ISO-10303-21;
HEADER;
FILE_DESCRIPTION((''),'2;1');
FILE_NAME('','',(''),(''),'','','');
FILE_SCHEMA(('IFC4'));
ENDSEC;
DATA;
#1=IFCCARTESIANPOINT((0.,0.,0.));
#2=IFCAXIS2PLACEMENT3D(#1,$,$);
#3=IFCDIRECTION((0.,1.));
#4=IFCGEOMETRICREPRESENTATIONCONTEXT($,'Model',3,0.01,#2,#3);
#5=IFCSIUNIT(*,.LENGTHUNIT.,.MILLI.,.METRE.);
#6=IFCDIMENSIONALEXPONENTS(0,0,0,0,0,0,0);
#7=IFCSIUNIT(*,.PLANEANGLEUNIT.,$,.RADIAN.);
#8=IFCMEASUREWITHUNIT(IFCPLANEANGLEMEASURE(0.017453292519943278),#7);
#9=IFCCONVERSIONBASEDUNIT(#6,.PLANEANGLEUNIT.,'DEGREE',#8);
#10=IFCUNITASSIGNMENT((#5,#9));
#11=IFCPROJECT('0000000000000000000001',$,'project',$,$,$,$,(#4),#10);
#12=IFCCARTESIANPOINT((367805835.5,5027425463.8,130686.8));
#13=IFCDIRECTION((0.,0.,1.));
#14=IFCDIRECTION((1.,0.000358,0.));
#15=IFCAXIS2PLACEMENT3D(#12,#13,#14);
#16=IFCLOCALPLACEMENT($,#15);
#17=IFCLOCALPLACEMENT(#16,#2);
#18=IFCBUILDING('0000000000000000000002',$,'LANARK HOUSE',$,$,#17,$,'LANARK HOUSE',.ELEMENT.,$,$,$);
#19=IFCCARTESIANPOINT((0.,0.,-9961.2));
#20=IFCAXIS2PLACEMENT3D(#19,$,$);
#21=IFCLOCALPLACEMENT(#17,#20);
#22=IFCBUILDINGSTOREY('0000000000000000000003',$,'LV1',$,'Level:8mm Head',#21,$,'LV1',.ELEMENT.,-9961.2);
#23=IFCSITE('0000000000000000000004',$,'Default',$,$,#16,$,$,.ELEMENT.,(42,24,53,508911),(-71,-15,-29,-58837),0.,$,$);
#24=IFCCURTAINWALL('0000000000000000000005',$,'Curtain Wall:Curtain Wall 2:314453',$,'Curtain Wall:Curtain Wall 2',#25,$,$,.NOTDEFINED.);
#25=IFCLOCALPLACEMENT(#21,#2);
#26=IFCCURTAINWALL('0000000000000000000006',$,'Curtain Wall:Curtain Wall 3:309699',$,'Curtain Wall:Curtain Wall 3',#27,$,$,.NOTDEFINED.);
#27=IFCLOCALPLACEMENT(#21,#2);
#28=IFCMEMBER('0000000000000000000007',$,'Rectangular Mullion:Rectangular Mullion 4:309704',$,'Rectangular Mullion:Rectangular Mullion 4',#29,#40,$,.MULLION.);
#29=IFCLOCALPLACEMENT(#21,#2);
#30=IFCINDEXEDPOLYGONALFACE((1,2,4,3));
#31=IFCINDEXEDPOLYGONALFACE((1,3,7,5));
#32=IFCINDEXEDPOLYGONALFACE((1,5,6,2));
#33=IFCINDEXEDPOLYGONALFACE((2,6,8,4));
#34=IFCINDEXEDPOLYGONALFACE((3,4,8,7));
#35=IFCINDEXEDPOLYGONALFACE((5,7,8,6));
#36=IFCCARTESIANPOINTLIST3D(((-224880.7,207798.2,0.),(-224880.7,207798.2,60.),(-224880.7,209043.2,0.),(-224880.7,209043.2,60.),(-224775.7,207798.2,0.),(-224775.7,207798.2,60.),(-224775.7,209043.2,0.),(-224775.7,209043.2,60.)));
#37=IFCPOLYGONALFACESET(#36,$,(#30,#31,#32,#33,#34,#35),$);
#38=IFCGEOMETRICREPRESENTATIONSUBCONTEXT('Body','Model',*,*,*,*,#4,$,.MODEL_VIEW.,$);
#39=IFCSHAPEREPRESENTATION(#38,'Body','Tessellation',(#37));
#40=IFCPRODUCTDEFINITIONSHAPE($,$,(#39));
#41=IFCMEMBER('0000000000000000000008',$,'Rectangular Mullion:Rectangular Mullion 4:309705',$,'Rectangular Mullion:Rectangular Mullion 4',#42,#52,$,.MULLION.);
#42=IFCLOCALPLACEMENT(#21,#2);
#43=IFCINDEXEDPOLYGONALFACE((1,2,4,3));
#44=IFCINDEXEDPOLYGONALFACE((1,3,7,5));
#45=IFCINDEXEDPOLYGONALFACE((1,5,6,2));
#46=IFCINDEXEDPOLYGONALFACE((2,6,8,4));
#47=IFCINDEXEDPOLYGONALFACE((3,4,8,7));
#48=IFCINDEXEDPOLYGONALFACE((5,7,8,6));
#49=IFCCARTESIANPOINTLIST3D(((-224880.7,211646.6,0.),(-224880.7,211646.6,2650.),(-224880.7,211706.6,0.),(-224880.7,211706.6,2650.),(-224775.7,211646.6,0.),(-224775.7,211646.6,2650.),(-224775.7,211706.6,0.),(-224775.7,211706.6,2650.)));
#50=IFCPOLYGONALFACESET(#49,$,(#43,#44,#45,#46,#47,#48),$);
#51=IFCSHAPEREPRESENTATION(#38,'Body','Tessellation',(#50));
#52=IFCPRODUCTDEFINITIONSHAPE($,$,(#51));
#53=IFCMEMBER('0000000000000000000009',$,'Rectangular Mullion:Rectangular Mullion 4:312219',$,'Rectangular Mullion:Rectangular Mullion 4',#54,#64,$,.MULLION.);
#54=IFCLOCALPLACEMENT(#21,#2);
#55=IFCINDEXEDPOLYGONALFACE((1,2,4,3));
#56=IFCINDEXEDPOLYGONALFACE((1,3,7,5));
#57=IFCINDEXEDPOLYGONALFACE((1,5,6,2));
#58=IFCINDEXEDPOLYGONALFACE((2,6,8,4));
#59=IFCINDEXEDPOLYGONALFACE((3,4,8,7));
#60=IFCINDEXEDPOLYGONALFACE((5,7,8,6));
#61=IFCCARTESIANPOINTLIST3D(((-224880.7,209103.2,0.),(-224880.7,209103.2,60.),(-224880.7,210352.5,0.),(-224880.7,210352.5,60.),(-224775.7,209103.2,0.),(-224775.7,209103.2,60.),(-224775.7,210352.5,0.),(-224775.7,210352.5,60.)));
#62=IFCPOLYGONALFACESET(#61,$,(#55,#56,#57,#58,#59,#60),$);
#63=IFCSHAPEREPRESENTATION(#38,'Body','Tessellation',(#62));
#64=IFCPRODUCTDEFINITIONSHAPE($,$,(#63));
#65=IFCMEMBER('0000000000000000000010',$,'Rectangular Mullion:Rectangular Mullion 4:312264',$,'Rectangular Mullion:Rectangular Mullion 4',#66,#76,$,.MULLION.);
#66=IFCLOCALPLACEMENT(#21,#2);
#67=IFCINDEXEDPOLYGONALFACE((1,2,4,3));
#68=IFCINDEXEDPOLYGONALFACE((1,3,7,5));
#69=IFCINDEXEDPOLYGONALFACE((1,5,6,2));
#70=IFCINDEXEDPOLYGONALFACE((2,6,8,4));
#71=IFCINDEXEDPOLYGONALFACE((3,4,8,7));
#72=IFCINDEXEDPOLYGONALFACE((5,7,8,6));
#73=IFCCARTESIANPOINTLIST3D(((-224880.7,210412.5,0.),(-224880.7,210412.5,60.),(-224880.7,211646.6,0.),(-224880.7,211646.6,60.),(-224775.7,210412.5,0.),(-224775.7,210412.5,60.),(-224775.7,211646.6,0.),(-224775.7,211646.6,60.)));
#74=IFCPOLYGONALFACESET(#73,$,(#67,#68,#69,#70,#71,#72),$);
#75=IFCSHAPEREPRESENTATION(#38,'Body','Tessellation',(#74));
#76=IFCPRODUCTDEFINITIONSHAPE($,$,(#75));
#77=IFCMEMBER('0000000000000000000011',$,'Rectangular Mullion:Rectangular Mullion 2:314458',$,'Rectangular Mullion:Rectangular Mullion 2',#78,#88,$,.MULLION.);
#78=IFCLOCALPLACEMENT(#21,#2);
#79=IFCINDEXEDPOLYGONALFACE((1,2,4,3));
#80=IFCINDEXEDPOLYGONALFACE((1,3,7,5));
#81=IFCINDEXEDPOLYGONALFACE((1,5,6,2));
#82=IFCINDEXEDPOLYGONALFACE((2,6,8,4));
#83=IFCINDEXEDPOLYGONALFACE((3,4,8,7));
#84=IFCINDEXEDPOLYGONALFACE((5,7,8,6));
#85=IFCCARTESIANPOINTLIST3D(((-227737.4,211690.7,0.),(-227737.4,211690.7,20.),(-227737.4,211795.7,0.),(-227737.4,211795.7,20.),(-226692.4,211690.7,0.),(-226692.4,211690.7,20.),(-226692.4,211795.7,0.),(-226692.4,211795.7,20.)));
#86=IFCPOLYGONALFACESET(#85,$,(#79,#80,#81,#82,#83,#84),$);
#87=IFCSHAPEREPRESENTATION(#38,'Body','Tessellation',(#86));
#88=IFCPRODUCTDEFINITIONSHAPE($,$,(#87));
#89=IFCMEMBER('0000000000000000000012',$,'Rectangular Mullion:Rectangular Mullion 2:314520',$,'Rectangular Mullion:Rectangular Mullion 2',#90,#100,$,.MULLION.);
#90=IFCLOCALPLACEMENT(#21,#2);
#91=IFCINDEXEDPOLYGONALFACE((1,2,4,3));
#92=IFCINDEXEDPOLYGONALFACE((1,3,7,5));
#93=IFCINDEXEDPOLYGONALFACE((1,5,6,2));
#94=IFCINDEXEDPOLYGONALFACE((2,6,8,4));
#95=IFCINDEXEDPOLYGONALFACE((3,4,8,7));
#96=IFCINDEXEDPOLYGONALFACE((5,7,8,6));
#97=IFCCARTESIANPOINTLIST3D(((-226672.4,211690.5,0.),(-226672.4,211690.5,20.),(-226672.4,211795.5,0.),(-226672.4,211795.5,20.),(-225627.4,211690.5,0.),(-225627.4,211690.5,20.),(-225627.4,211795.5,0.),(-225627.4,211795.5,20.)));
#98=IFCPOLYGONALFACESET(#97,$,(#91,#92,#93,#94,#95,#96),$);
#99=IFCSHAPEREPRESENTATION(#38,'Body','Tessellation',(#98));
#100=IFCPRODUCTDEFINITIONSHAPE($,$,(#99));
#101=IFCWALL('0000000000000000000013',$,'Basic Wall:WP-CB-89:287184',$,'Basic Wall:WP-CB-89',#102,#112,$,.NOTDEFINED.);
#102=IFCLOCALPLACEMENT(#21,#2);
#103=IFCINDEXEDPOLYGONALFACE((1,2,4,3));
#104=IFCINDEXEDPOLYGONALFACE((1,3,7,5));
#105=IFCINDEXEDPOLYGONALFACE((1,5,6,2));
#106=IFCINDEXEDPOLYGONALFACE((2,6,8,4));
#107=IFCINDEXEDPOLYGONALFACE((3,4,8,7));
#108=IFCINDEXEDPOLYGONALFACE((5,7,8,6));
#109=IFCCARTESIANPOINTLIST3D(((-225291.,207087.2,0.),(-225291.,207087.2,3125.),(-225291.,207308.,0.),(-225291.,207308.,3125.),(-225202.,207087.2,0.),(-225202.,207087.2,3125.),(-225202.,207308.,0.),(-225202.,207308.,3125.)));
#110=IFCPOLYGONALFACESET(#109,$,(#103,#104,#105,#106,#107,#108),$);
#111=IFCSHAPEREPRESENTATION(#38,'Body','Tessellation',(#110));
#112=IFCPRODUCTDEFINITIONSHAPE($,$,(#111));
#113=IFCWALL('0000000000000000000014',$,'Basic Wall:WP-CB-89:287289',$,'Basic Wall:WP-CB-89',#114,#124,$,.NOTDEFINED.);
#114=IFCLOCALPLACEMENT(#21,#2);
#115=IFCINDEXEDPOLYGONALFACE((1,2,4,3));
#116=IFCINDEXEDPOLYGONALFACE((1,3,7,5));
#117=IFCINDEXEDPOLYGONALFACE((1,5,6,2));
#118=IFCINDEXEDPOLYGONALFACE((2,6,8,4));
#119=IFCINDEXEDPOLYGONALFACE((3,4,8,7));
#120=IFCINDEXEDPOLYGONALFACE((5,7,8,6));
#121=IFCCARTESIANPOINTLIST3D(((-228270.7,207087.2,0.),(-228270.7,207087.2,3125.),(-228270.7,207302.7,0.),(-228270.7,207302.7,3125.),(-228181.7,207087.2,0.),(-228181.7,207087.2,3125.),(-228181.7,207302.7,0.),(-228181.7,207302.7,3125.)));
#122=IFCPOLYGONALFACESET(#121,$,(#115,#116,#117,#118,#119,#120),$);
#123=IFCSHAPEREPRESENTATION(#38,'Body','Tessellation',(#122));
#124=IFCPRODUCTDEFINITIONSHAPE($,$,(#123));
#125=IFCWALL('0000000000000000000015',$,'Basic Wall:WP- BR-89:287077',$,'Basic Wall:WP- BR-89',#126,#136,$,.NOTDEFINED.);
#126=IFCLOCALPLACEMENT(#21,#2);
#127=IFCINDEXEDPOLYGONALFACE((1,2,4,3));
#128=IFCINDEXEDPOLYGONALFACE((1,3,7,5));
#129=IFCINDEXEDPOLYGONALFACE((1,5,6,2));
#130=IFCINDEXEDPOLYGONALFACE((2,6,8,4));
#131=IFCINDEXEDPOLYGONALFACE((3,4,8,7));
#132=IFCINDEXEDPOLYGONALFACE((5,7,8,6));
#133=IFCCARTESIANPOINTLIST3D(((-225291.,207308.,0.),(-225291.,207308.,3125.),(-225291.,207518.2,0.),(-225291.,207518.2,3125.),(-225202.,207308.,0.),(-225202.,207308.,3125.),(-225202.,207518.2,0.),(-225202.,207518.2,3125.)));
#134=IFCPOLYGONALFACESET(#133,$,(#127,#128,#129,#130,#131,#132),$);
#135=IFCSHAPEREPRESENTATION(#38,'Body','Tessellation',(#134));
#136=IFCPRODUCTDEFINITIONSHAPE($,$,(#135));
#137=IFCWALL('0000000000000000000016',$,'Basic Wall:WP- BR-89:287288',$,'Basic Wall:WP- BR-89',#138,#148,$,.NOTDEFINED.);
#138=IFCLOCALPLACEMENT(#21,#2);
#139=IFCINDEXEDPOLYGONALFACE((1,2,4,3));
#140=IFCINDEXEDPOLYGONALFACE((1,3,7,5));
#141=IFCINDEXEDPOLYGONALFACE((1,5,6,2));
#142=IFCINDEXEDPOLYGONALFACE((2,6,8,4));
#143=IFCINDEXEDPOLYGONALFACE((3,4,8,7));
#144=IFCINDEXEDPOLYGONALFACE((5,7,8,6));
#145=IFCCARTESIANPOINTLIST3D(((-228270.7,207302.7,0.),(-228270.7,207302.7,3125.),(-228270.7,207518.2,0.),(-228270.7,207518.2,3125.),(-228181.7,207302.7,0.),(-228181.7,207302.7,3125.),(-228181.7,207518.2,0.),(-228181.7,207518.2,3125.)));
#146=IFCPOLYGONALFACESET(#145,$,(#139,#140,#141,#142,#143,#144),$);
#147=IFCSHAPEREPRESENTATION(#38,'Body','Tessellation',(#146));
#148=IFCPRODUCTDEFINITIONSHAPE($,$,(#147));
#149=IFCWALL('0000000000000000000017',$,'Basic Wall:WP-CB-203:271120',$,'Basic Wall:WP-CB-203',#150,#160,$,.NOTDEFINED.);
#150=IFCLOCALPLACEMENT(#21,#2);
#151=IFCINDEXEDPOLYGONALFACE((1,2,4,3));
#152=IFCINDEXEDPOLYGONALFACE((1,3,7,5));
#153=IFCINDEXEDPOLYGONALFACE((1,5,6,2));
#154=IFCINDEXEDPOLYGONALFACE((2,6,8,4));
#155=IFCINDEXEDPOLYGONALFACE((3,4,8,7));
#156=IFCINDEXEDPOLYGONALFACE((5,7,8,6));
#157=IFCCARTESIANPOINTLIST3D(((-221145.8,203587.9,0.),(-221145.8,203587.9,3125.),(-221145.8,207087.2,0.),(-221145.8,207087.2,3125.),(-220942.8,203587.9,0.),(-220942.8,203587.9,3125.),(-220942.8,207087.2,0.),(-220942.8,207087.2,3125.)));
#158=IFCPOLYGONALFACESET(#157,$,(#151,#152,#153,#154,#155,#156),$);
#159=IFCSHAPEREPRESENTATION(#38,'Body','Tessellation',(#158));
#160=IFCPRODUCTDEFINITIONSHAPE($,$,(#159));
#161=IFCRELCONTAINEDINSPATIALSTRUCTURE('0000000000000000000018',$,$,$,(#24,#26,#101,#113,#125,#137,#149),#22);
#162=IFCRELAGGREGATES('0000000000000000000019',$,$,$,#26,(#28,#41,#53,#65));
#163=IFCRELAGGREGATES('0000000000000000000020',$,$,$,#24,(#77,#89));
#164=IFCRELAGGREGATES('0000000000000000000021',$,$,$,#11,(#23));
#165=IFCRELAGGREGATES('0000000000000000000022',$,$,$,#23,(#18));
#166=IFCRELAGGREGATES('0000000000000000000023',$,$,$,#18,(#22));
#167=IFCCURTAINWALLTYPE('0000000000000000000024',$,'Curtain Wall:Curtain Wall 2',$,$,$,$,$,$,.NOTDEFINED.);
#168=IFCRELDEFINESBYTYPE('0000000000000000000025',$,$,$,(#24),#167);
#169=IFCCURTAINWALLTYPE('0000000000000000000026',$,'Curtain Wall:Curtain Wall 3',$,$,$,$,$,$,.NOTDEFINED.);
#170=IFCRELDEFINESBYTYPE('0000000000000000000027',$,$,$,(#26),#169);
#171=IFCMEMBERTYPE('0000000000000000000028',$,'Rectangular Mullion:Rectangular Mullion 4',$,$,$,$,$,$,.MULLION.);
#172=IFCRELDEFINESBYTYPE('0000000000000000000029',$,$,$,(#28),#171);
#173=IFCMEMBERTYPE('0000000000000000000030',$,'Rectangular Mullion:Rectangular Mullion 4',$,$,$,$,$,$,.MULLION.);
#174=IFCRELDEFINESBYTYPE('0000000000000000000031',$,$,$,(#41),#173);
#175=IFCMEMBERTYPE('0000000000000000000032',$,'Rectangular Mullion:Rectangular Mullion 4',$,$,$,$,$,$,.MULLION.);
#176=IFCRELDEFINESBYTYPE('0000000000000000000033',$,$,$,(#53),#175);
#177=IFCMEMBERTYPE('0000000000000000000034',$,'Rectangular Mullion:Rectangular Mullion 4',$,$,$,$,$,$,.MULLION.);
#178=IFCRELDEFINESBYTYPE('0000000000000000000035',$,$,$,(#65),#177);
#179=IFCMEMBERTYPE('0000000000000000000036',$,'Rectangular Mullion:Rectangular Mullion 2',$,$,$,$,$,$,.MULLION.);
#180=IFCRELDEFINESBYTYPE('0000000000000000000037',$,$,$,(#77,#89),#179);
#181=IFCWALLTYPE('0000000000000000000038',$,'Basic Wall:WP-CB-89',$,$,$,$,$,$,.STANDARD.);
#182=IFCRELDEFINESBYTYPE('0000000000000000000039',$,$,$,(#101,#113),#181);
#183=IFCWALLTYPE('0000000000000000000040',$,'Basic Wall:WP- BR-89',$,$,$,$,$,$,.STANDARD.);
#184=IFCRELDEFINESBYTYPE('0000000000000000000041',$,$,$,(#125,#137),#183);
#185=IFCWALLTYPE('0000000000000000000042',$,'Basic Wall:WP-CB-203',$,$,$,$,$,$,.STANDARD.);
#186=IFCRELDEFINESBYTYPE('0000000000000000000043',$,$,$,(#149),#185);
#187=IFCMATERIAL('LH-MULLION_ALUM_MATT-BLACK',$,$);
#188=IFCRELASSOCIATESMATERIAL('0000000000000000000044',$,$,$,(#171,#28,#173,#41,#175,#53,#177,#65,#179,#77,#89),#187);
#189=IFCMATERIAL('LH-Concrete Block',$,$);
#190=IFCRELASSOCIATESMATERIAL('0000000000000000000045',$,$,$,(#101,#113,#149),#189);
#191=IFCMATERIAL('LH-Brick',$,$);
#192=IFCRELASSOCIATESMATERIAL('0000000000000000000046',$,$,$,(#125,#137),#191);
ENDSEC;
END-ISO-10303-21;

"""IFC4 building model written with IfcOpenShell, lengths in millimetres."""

from ifc_helpers import new_model, entity, si_unit, converted_unit, direction, frame, origin, place, context, subcontext, project, spatial, indexed_curve, outline, extrude, source, transform, mapped, material, type_object, type_shapes, element, aggregate, save


model = new_model("IFC4")

# Units and contexts
model_context = context("Model", 3, precision=0.01, world=origin(), true_north=direction((0.0, 1.0)))
body_context = subcontext(model_context, "Body", "Model", "MODEL_VIEW")
ifc_project = project(units=[si_unit("LENGTHUNIT", "METRE", prefix="MILLI"), converted_unit("PLANEANGLEUNIT", "DEGREE", entity("IfcPlaneAngleMeasure", 0.017453292519943278), si_unit("PLANEANGLEUNIT", "RADIAN"), dimensions=[0, 0, 0, 0, 0, 0, 0])], contexts=[model_context])

# Site, building, storey
site_placement = place(None, frame((367805835.5, 5027425463.8, 130686.8), z_axis=(0.0, 0.0, 1.0), x_axis=(1.0, 0.000358, 0.0)))
site = spatial("IfcSite", under=ifc_project, at=site_placement, Name="Default", CompositionType="ELEMENT", RefLatitude=(42, 24, 53, 508911), RefLongitude=(-71, -15, -29, -58837), RefElevation=0.0)
building_placement = place(site_placement, origin())
building = spatial("IfcBuilding", under=site, at=building_placement, Name="LANARK HOUSE", LongName="LANARK HOUSE", CompositionType="ELEMENT")
storey_placement = place(building_placement, frame((0.0, 0.0, -9961.2)))
storey = spatial("IfcBuildingStorey", under=building, at=storey_placement, Name="LV1", ObjectType="Level:8mm Head", LongName="LV1", CompositionType="ELEMENT", Elevation=-9961.2)

# Shared definitions
curtain_wall_type_1 = type_object("IfcCurtainWallType", Name="Curtain Wall:Curtain Wall 2", PredefinedType="NOTDEFINED")
ifc_material_1 = material(Name="LH-MULLION_ALUM_MATT-BLACK")

# Curtain wall
curtain_wall_1_placement = place(storey_placement, frame((0.0, 0.0, 9961.2)))
curtain_wall_1 = element("IfcCurtainWall", 1, at=curtain_wall_1_placement, inside=storey, type_object=curtain_wall_type_1, Name="Curtain Wall:Curtain Wall 2:314453", ObjectType="Curtain Wall:Curtain Wall 2", PredefinedType="NOTDEFINED")

# Curtain wall
curtain_wall_type_2 = type_object("IfcCurtainWallType", Name="Curtain Wall:Curtain Wall 3", PredefinedType="NOTDEFINED")
curtain_wall_2_placement = place(storey_placement, frame((0.0, 0.0, 9961.2)))
curtain_wall_2 = element("IfcCurtainWall", 2, at=curtain_wall_2_placement, inside=storey, type_object=curtain_wall_type_2, Name="Curtain Wall:Curtain Wall 3:309699", ObjectType="Curtain Wall:Curtain Wall 3", PredefinedType="NOTDEFINED")

# Members
member_type_1 = type_object("IfcMemberType", Name="Rectangular Mullion:Rectangular Mullion 4", PredefinedType="MULLION", material=ifc_material_1)
shared_shape_1 = source(origin(), body_context, "Body", "SweptSolid", [
    extrude(outline(indexed_curve([(-30.0, -52.5), (30.0, -52.5), (30.0, 52.5), (-30.0, 52.5), (-30.0, -52.5)], self_intersect=False)), frame((-30.0, -40.0, -1245.0), z_axis=(0.0, 0.0, 1.0), x_axis=(-1.0, 0.0, 0.0)), (0.0, 0.0, 1.0), 1245.0),
])
type_shapes(member_type_1, [shared_shape_1])
member_1_placement = place(curtain_wall_2_placement, frame((-224788.2, 207798.2, -9961.2), z_axis=(0.0, -1.0, 0.0), x_axis=(0.0, 0.0, -1.0)))
member_1 = element("IfcMember", 3, at=member_1_placement, type_object=member_type_1, material=ifc_material_1, Name="Rectangular Mullion:Rectangular Mullion 4:309704", ObjectType="Rectangular Mullion:Rectangular Mullion 4", PredefinedType="MULLION", context=body_context, shape_type="MappedRepresentation", body=[
    mapped(shared_shape_1, transform((0.0, 0.0, 0.0), scale=1.0)),
])
member_type_2 = type_object("IfcMemberType", Name="Rectangular Mullion:Rectangular Mullion 4", PredefinedType="MULLION", material=ifc_material_1)
shared_shape_2 = source(origin(), body_context, "Body", "SweptSolid", [
    extrude(outline(indexed_curve([(-30.0, -52.5), (30.0, -52.5), (30.0, 52.5), (-30.0, 52.5), (-30.0, -52.5)], self_intersect=False)), frame((-30.0, -40.0, -2650.0), z_axis=(0.0, 0.0, 1.0), x_axis=(-1.0, 0.0, 0.0)), (0.0, 0.0, 1.0), 2650.0),
])
type_shapes(member_type_2, [shared_shape_2])
member_2_placement = place(curtain_wall_2_placement, frame((-224788.2, 211706.6, -9961.2), z_axis=(0.0, 0.0, -1.0), x_axis=(0.0, 1.0, 0.0)))
member_2 = element("IfcMember", 4, at=member_2_placement, type_object=member_type_2, material=ifc_material_1, Name="Rectangular Mullion:Rectangular Mullion 4:309705", ObjectType="Rectangular Mullion:Rectangular Mullion 4", PredefinedType="MULLION", context=body_context, shape_type="MappedRepresentation", body=[
    mapped(shared_shape_2, transform((0.0, 0.0, 0.0), scale=1.0)),
])
member_type_3 = type_object("IfcMemberType", Name="Rectangular Mullion:Rectangular Mullion 4", PredefinedType="MULLION", material=ifc_material_1)
shared_shape_3 = source(origin(), body_context, "Body", "SweptSolid", [
    extrude(outline(indexed_curve([(-30.0, -52.5), (30.0, -52.5), (30.0, 52.5), (-30.0, 52.5), (-30.0, -52.5)], self_intersect=False)), frame((-30.0, -40.0, -1249.3), z_axis=(0.0, 0.0, 1.0), x_axis=(-1.0, 0.0, 0.0)), (0.0, 0.0, 1.0), 1249.3),
])
type_shapes(member_type_3, [shared_shape_3])
member_3_placement = place(curtain_wall_2_placement, frame((-224788.2, 209103.2, -9961.2), z_axis=(0.0, -1.0, 0.0), x_axis=(0.0, 0.0, -1.0)))
member_3 = element("IfcMember", 5, at=member_3_placement, type_object=member_type_3, material=ifc_material_1, Name="Rectangular Mullion:Rectangular Mullion 4:312219", ObjectType="Rectangular Mullion:Rectangular Mullion 4", PredefinedType="MULLION", context=body_context, shape_type="MappedRepresentation", body=[
    mapped(shared_shape_3, transform((0.0, 0.0, 0.0), scale=1.0)),
])
member_type_4 = type_object("IfcMemberType", Name="Rectangular Mullion:Rectangular Mullion 4", PredefinedType="MULLION", material=ifc_material_1)
shared_shape_4 = source(origin(), body_context, "Body", "SweptSolid", [
    extrude(outline(indexed_curve([(-30.0, -52.5), (30.0, -52.5), (30.0, 52.5), (-30.0, 52.5), (-30.0, -52.5)], self_intersect=False)), frame((-30.0, -40.0, -1234.1), z_axis=(0.0, 0.0, 1.0), x_axis=(-1.0, 0.0, 0.0)), (0.0, 0.0, 1.0), 1234.1),
])
type_shapes(member_type_4, [shared_shape_4])
member_4_placement = place(curtain_wall_2_placement, frame((-224788.2, 210412.5, -9961.2), z_axis=(0.0, -1.0, 0.0), x_axis=(0.0, 0.0, -1.0)))
member_4 = element("IfcMember", 6, at=member_4_placement, type_object=member_type_4, material=ifc_material_1, Name="Rectangular Mullion:Rectangular Mullion 4:312264", ObjectType="Rectangular Mullion:Rectangular Mullion 4", PredefinedType="MULLION", context=body_context, shape_type="MappedRepresentation", body=[
    mapped(shared_shape_4, transform((0.0, 0.0, 0.0), scale=1.0)),
])
aggregate(curtain_wall_2, [member_1, member_2, member_3, member_4])
member_type_5 = type_object("IfcMemberType", Name="Rectangular Mullion:Rectangular Mullion 2", PredefinedType="MULLION", material=ifc_material_1)
shared_shape_5 = source(origin(), body_context, "Body", "SweptSolid", [
    extrude(outline(indexed_curve([(-10.0, -52.5), (10.0, -52.5), (10.0, 52.5), (-10.0, 52.5), (-10.0, -52.5)], self_intersect=False)), frame((-10.0, -40.0, -1045.0), z_axis=(0.0, 0.0, 1.0), x_axis=(-1.0, 0.0, 0.0)), (0.0, 0.0, 1.0), 1045.0),
])
type_shapes(member_type_5, [shared_shape_5])
member_5_placement = place(curtain_wall_1_placement, frame((-227737.4, 211703.2, -9961.2), z_axis=(-1.0, 0.0, 0.0), x_axis=(0.0, 0.0, -1.0)))
member_5 = element("IfcMember", 7, at=member_5_placement, type_object=member_type_5, material=ifc_material_1, Name="Rectangular Mullion:Rectangular Mullion 2:314458", ObjectType="Rectangular Mullion:Rectangular Mullion 2", PredefinedType="MULLION", context=body_context, shape_type="MappedRepresentation", body=[
    mapped(shared_shape_5, transform((0.0, 0.0, 0.0), scale=1.0)),
])
member_6_placement = place(curtain_wall_1_placement, frame((-226672.4, 211703.0, -9961.2), z_axis=(-1.0, 0.0, 0.0), x_axis=(0.0, 0.0, -1.0)))
member_6 = element("IfcMember", 8, at=member_6_placement, type_object=member_type_5, material=ifc_material_1, Name="Rectangular Mullion:Rectangular Mullion 2:314520", ObjectType="Rectangular Mullion:Rectangular Mullion 2", PredefinedType="MULLION", context=body_context, shape_type="MappedRepresentation", body=[
    mapped(shared_shape_5, transform((0.0, 0.0, 0.0), scale=1.0)),
])
aggregate(curtain_wall_1, [member_5, member_6])

# Walls
ifc_material_2 = material(Name="LH-Concrete Block")
wall_type_1 = type_object("IfcWallType", Name="Basic Wall:WP-CB-89", PredefinedType="STANDARD")
wall_1_placement = place(storey_placement, frame((-225246.5, 207087.2, 0.0), z_axis=(0.0, 0.0, 1.0), x_axis=(0.0, 1.0, 0.0)))
element("IfcWall", 9, at=wall_1_placement, inside=storey, type_object=wall_type_1, material=ifc_material_2, Name="Basic Wall:WP-CB-89:287184", ObjectType="Basic Wall:WP-CB-89", PredefinedType="NOTDEFINED", context=body_context, shape_type="SweptSolid", body=[
    extrude(outline(indexed_curve([(220.8, 44.5), (0.0, 44.5), (0.0, -44.5), (220.8, -44.5), (220.8, 44.5)], self_intersect=False)), origin(), (0.0, 0.0, 1.0), 3125.0),
])
wall_2_placement = place(storey_placement, frame((-228226.2, 207087.2, 0.0), z_axis=(0.0, 0.0, 1.0), x_axis=(0.0, 1.0, 0.0)))
element("IfcWall", 10, at=wall_2_placement, inside=storey, type_object=wall_type_1, material=ifc_material_2, Name="Basic Wall:WP-CB-89:287289", ObjectType="Basic Wall:WP-CB-89", PredefinedType="NOTDEFINED", context=body_context, shape_type="SweptSolid", body=[
    extrude(outline(indexed_curve([(215.5, 44.5), (0.0, 44.5), (0.0, -44.5), (215.5, -44.5), (215.5, 44.5)], self_intersect=False)), origin(), (0.0, 0.0, 1.0), 3125.0),
])
ifc_material_3 = material(Name="LH-Brick")
wall_type_2 = type_object("IfcWallType", Name="Basic Wall:WP- BR-89", PredefinedType="STANDARD")
wall_3_placement = place(storey_placement, frame((-225246.5, 207308.0, 0.0), z_axis=(0.0, 0.0, 1.0), x_axis=(0.0, 1.0, 0.0)))
element("IfcWall", 11, at=wall_3_placement, inside=storey, type_object=wall_type_2, material=ifc_material_3, Name="Basic Wall:WP- BR-89:287077", ObjectType="Basic Wall:WP- BR-89", PredefinedType="NOTDEFINED", context=body_context, shape_type="SweptSolid", body=[
    extrude(outline(indexed_curve([(210.2, 44.5), (0.0, 44.5), (0.0, -44.5), (210.2, -44.5), (210.2, 44.5)], self_intersect=False)), origin(), (0.0, 0.0, 1.0), 3125.0),
])
wall_4_placement = place(storey_placement, frame((-228226.2, 207302.7, 0.0), z_axis=(0.0, 0.0, 1.0), x_axis=(0.0, 1.0, 0.0)))
element("IfcWall", 12, at=wall_4_placement, inside=storey, type_object=wall_type_2, material=ifc_material_3, Name="Basic Wall:WP- BR-89:287288", ObjectType="Basic Wall:WP- BR-89", PredefinedType="NOTDEFINED", context=body_context, shape_type="SweptSolid", body=[
    extrude(outline(indexed_curve([(215.5, 44.5), (0.0, 44.5), (0.0, -44.5), (215.5, -44.5), (215.5, 44.5)], self_intersect=False)), origin(), (0.0, 0.0, 1.0), 3125.0),
])
wall_type_3 = type_object("IfcWallType", Name="Basic Wall:WP-CB-203", PredefinedType="STANDARD")
wall_5_placement = place(storey_placement, frame((-221044.3, 207087.2, 0.0), z_axis=(0.0, 0.0, 1.0), x_axis=(0.0, -1.0, 0.0)))
element("IfcWall", 13, at=wall_5_placement, inside=storey, type_object=wall_type_3, material=ifc_material_2, Name="Basic Wall:WP-CB-203:271120", ObjectType="Basic Wall:WP-CB-203", PredefinedType="NOTDEFINED", context=body_context, shape_type="SweptSolid", body=[
    extrude(outline(indexed_curve([(3499.4, 101.5), (0.0, 101.5), (0.0, -101.5), (3499.4, -101.5), (3499.4, 101.5)], self_intersect=False)), origin(), (0.0, 0.0, 1.0), 3125.0),
])

save(model, "model.ifc")
